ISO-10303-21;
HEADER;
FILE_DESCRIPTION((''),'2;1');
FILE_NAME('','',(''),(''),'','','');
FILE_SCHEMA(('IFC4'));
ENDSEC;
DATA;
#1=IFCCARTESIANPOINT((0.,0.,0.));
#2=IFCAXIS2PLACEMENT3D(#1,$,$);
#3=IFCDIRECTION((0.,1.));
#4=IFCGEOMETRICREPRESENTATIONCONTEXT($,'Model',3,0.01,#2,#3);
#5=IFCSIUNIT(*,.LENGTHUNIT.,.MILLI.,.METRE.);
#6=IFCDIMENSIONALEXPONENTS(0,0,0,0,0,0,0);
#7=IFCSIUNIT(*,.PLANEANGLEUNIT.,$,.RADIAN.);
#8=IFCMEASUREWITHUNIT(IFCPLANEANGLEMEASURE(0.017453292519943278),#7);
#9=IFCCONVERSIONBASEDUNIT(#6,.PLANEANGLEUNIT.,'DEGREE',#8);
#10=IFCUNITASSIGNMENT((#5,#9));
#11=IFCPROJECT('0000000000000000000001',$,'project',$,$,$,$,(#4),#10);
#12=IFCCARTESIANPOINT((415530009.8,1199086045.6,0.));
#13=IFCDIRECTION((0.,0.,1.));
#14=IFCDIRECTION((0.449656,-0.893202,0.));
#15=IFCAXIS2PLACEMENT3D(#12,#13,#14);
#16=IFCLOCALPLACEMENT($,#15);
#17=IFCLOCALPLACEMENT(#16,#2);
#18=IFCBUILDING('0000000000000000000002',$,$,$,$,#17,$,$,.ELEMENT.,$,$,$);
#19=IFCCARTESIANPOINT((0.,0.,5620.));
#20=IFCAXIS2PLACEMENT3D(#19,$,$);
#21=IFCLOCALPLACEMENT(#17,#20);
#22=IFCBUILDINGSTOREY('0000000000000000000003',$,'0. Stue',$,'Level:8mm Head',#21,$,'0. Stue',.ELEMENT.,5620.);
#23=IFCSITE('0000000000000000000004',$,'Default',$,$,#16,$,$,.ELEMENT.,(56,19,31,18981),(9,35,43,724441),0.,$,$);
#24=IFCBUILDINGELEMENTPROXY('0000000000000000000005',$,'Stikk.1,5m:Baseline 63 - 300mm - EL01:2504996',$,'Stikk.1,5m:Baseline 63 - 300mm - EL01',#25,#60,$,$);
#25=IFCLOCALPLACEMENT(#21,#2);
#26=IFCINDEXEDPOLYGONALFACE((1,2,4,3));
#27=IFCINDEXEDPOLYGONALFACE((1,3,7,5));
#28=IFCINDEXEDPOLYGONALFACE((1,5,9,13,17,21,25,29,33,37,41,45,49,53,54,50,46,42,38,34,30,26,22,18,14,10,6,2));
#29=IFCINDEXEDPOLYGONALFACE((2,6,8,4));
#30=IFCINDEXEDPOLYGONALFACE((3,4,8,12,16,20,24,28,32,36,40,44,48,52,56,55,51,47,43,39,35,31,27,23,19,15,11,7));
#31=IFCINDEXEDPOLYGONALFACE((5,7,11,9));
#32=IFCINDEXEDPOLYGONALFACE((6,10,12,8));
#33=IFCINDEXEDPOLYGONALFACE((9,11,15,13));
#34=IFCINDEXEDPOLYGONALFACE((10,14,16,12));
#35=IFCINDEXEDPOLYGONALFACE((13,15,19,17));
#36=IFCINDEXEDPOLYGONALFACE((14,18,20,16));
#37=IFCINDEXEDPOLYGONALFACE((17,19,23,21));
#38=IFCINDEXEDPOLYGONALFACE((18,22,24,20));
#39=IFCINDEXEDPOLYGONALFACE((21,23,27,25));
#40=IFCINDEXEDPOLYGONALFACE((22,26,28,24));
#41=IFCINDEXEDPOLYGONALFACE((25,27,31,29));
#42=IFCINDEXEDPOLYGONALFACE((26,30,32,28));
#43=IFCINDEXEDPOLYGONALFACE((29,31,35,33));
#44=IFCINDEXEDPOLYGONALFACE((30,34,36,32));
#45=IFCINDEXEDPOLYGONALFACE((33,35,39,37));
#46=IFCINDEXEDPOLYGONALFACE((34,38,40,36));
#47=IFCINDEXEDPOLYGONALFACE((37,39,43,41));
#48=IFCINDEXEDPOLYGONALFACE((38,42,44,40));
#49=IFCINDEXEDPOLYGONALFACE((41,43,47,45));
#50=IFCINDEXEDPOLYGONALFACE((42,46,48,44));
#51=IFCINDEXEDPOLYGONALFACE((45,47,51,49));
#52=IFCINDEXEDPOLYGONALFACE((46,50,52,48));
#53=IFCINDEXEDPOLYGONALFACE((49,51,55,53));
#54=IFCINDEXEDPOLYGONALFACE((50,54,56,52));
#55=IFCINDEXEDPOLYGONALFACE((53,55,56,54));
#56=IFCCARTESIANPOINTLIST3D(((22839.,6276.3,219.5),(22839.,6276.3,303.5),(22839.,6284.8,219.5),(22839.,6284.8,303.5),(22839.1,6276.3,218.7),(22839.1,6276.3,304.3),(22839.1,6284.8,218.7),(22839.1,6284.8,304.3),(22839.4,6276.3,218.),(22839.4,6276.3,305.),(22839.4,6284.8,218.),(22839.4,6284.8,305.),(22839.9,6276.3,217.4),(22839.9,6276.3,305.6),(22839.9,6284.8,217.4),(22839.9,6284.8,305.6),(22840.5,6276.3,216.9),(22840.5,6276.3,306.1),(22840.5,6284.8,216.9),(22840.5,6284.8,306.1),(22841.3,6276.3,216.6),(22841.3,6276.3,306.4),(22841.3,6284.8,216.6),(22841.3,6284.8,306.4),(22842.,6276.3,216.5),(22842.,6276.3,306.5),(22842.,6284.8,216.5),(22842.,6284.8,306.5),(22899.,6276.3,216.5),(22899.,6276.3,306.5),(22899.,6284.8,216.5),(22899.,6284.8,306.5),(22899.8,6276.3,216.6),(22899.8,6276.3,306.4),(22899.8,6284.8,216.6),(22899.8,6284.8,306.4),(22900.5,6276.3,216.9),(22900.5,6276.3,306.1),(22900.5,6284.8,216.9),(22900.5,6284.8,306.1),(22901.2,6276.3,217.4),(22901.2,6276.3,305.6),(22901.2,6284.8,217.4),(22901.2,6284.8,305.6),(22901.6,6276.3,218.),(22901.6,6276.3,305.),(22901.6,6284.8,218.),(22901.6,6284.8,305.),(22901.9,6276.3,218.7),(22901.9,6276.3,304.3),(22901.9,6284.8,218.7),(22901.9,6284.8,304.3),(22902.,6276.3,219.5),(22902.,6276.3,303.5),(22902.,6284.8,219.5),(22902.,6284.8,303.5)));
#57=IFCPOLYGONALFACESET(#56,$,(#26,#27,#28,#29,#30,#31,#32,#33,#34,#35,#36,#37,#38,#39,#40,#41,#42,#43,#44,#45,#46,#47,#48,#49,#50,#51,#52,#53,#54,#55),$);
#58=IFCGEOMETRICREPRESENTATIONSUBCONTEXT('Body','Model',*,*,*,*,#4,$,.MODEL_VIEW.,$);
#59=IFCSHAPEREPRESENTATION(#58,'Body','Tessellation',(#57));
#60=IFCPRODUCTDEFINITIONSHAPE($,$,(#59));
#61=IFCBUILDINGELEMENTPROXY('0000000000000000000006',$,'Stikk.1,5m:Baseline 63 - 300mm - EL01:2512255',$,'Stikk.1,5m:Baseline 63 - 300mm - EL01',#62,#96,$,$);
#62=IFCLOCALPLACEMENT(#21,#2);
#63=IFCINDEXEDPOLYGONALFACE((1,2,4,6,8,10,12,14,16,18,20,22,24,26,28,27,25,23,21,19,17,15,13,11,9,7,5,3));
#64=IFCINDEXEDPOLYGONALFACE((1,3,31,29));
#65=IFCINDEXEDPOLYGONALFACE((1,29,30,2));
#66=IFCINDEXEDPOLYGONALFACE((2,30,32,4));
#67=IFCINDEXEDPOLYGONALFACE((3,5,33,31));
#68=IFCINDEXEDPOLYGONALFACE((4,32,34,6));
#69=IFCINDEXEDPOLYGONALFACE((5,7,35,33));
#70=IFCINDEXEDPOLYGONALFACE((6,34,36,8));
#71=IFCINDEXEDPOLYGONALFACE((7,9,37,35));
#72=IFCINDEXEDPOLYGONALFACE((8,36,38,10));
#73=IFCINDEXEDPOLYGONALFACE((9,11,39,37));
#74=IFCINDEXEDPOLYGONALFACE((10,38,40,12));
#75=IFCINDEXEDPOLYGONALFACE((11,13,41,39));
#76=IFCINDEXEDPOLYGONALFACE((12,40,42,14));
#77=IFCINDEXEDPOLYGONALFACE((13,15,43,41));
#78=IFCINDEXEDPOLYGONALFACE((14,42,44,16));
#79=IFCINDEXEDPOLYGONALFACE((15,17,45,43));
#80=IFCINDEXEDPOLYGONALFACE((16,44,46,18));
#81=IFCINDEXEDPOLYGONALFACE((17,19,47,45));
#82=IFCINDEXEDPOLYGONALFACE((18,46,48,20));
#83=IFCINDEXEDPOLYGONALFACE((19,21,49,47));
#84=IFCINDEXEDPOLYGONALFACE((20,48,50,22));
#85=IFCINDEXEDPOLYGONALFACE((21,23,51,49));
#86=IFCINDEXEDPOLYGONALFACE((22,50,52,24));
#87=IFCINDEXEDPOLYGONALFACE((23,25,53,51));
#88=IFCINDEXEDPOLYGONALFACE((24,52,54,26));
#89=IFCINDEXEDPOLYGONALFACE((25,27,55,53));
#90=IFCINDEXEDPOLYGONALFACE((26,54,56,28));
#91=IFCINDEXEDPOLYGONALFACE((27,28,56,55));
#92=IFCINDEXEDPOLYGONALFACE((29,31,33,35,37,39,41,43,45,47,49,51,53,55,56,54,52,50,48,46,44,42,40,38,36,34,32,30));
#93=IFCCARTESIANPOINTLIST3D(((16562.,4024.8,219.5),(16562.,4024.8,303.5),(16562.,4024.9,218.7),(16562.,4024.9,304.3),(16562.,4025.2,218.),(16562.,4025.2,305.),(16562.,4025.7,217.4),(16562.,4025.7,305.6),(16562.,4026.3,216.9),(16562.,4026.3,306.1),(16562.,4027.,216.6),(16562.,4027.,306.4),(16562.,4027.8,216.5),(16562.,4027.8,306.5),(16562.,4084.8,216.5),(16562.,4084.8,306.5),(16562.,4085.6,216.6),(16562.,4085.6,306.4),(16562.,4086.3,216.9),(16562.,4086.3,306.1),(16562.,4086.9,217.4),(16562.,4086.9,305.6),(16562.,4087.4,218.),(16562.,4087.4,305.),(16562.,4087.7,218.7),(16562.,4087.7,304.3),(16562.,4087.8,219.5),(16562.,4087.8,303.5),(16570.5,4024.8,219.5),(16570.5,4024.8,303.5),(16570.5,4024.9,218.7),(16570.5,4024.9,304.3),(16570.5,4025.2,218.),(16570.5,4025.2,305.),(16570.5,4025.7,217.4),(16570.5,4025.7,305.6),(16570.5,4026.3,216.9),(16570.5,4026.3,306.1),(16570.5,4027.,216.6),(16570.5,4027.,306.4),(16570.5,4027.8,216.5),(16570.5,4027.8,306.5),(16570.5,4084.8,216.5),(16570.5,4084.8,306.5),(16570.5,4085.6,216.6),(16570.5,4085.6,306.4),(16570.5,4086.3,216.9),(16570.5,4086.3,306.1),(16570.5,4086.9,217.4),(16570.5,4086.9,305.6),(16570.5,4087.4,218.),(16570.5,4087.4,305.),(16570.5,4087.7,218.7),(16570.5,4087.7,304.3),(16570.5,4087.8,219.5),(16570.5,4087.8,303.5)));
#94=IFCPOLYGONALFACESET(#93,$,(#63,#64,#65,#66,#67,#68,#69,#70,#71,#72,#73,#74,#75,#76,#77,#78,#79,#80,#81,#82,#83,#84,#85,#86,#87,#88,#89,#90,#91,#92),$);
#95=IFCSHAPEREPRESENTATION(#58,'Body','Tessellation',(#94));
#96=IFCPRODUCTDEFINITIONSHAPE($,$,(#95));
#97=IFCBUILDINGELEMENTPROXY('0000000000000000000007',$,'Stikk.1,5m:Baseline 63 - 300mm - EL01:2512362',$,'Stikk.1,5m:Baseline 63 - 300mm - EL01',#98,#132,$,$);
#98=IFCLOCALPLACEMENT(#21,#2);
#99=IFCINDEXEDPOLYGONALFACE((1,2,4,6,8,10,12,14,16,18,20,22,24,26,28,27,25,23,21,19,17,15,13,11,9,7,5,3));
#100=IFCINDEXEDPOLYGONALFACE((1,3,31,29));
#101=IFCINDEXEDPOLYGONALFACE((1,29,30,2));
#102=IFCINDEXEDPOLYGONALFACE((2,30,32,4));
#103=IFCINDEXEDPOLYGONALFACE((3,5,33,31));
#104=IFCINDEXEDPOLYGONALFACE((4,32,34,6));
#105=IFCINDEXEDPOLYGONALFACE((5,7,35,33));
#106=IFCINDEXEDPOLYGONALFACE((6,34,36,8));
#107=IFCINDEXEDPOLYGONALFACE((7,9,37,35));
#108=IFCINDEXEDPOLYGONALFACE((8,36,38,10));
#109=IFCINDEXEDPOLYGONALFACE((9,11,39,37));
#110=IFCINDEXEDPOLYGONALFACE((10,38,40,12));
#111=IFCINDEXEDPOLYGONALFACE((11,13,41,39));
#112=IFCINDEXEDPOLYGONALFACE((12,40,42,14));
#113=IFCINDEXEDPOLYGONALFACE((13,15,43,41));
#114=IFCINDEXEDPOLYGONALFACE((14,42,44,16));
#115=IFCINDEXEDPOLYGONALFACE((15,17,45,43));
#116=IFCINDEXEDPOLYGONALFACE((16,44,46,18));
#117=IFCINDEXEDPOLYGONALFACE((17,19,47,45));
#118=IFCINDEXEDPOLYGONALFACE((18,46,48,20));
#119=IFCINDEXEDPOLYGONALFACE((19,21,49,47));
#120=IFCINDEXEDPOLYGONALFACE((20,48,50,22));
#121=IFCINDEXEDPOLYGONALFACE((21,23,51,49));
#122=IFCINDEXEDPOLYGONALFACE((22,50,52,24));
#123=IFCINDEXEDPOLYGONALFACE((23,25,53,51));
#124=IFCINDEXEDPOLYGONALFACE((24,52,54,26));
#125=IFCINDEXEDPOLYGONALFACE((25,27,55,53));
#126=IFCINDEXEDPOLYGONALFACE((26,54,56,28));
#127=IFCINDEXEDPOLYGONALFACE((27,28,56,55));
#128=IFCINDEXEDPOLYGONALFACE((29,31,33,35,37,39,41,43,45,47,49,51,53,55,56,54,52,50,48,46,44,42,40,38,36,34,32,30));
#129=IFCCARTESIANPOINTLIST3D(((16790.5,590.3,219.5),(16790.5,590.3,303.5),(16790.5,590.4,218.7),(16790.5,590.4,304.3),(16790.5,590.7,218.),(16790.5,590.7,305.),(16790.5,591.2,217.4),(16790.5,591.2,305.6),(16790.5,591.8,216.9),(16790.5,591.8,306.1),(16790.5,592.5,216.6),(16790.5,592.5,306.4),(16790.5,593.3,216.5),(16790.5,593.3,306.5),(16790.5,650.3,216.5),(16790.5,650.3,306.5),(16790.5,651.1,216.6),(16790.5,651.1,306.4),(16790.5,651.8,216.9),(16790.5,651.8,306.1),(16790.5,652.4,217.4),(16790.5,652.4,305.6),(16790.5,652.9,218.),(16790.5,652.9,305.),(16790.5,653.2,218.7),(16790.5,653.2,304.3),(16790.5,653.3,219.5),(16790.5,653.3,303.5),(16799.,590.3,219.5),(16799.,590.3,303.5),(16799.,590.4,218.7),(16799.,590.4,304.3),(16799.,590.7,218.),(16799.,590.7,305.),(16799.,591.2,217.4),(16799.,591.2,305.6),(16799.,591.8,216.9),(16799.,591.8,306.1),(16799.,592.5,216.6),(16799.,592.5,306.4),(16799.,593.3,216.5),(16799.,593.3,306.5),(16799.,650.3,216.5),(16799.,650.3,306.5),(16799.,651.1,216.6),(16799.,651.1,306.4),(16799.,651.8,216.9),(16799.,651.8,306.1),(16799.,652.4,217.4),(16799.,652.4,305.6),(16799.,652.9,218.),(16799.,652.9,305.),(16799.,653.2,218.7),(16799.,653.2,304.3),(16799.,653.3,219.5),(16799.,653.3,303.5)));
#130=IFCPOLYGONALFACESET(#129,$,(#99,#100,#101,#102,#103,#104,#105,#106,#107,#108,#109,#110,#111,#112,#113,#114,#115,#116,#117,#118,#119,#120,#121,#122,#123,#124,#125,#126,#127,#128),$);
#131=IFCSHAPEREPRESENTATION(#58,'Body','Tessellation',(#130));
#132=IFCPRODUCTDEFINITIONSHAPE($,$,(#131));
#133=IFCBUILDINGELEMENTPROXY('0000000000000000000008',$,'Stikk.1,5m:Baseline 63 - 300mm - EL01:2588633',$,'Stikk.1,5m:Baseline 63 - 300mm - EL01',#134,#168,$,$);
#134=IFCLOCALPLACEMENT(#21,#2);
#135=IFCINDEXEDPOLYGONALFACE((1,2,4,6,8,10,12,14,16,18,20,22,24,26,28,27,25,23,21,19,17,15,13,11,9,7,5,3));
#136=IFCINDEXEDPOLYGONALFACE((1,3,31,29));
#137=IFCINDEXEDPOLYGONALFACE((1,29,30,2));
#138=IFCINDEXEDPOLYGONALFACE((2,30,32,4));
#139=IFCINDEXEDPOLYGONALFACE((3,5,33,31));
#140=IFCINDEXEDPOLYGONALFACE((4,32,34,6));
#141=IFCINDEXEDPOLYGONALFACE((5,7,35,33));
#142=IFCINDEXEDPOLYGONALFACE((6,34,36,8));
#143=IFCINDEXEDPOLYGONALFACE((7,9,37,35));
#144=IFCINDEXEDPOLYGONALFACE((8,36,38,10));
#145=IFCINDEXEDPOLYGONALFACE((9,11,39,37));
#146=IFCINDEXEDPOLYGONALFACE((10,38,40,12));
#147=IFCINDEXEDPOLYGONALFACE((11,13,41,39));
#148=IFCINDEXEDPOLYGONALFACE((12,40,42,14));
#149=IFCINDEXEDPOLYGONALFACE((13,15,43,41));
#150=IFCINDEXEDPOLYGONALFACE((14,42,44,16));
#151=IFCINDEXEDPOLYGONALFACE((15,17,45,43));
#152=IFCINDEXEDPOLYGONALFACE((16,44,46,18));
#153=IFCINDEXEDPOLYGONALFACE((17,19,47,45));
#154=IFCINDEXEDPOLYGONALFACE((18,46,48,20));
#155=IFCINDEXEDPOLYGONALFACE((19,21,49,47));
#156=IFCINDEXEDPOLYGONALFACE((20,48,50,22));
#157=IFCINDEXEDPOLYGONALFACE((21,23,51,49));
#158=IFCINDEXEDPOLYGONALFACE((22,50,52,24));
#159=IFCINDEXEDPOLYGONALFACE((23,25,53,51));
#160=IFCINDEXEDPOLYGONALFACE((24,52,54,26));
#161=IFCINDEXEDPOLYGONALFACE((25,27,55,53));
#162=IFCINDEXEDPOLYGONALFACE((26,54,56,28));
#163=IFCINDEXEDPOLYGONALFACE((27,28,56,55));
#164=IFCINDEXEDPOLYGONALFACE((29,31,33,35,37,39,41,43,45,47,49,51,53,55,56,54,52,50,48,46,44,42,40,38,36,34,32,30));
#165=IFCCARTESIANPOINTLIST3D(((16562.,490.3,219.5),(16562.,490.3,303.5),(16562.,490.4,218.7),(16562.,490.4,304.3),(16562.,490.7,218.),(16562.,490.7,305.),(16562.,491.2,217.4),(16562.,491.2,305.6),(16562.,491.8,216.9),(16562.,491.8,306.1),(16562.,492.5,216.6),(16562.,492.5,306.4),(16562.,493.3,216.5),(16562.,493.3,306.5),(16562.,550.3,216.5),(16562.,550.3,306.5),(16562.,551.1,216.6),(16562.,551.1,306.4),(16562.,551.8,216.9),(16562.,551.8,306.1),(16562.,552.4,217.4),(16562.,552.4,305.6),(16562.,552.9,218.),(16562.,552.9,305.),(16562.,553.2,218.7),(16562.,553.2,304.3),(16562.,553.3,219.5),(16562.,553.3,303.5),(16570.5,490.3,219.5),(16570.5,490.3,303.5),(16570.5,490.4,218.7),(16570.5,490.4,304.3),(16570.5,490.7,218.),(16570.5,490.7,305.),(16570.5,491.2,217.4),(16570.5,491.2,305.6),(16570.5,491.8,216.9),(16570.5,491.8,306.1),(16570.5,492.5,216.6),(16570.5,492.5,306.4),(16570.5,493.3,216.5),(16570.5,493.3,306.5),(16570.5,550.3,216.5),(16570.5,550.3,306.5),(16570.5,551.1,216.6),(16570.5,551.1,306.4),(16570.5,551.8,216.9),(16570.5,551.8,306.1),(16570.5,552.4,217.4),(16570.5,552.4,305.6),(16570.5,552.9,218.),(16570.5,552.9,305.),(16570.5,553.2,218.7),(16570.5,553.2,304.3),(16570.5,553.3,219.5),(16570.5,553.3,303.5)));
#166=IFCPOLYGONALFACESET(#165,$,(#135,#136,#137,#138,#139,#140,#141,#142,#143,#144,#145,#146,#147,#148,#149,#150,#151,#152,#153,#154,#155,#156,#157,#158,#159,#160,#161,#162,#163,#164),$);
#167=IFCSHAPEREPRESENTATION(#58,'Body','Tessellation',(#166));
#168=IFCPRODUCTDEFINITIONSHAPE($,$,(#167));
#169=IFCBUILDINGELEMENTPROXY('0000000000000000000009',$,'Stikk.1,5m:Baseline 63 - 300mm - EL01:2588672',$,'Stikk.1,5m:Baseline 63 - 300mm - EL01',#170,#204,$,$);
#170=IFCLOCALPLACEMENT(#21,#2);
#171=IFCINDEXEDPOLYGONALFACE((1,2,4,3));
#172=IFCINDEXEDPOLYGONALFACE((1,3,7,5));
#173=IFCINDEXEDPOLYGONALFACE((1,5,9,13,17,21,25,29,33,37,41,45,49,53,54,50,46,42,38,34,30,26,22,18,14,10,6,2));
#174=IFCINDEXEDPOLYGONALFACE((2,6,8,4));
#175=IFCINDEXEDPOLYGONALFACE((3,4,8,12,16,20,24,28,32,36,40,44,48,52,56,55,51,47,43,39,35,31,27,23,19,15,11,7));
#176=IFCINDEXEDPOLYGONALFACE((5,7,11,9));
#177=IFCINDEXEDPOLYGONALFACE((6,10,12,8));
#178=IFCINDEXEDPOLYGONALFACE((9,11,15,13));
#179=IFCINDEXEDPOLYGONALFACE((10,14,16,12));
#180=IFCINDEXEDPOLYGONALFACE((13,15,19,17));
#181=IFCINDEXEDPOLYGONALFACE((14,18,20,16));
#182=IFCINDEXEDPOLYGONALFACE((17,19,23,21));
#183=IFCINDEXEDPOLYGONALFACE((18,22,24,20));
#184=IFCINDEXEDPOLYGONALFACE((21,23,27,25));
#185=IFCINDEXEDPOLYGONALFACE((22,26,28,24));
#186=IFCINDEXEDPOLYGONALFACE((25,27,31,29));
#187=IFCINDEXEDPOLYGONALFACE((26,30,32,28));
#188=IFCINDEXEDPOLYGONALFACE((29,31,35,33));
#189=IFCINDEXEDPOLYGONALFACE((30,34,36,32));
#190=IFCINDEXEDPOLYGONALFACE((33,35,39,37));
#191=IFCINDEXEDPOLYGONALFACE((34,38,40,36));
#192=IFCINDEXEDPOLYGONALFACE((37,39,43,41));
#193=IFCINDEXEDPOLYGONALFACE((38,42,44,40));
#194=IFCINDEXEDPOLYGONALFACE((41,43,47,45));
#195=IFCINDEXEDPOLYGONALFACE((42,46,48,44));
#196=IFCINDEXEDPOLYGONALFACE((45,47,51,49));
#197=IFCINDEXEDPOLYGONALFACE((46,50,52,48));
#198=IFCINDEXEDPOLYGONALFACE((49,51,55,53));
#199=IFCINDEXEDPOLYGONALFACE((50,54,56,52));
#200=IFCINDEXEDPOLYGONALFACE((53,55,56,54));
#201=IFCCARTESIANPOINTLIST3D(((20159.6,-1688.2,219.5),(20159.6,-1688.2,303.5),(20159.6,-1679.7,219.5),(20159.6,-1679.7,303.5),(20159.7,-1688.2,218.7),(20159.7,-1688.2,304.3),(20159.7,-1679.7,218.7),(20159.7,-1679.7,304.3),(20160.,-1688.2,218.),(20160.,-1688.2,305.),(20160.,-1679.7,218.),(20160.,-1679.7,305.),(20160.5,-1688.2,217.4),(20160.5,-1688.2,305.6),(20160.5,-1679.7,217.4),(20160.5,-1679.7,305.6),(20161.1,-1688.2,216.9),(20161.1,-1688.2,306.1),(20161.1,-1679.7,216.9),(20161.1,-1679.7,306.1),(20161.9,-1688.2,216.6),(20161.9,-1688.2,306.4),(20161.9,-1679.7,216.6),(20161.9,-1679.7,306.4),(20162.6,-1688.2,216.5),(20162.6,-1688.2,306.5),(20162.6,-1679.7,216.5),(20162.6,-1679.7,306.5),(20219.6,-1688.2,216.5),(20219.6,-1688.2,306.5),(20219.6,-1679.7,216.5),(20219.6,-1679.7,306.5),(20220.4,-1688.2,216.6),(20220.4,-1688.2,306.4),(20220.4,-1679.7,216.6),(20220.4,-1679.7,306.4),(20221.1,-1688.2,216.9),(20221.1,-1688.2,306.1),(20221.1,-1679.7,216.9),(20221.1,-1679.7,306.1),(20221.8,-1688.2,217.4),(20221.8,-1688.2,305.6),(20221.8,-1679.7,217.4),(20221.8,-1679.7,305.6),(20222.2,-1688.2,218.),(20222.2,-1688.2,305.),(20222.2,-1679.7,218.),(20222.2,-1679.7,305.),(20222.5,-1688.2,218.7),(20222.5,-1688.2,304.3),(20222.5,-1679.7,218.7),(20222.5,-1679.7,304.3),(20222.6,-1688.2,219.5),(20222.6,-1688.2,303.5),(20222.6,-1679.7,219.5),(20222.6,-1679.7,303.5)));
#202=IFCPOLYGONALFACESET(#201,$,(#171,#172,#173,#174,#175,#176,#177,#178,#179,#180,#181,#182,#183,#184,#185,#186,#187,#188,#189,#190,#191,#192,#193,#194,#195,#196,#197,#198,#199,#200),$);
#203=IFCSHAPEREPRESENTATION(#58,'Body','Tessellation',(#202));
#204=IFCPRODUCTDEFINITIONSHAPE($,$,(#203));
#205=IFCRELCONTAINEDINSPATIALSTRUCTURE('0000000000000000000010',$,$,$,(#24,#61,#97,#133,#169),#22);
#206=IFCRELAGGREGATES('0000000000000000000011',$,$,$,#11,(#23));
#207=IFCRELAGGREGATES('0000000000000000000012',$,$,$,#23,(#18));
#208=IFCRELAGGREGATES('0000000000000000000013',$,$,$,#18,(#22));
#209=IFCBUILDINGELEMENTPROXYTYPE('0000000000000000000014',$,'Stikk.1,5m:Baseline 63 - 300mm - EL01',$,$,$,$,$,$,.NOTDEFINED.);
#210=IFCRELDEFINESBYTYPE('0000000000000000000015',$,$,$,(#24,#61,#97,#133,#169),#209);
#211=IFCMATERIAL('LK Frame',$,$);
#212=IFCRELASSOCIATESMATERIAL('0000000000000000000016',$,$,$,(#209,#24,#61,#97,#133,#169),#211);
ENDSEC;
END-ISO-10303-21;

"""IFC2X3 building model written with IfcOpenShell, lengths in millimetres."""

from ifc_helpers import new_model, entity, si_unit, converted_unit, direction, frame, frame_2d, origin, place, context, subcontext, project, spatial, polyline, circle_curve, parameter, trimmed, segment, composite_curve, outline, extrude, source, transform, mapped, material, type_object, type_shapes, element, save


model = new_model("IFC2X3")

# Units and contexts
model_context = context("Model", 3, precision=0.01, world=origin(), true_north=direction((0.0, 1.0)))
body_context = subcontext(model_context, "Body", "Model", "MODEL_VIEW")
ifc_project = project(units=[si_unit("LENGTHUNIT", "METRE", prefix="MILLI"), converted_unit("PLANEANGLEUNIT", "DEGREE", entity("IfcPlaneAngleMeasure", 0.017453292519943278), si_unit("PLANEANGLEUNIT", "RADIAN"), dimensions=[0, 0, 0, 0, 0, 0, 0])], contexts=[model_context])

# Site, building, storey
site_placement = place(None, frame((415530009.8, 1199086045.6, 0.0), z_axis=(0.0, 0.0, 1.0), x_axis=(0.449656, -0.893202, 0.0)))
site = spatial("IfcSite", under=ifc_project, at=site_placement, Name="Default", CompositionType="ELEMENT", RefLatitude=(56, 19, 31, 18981), RefLongitude=(9, 35, 43, 724441), RefElevation=0.0)
building_placement = place(site_placement, origin())
building = spatial("IfcBuilding", under=site, at=building_placement, CompositionType="ELEMENT")
storey_placement = place(building_placement, frame((0.0, 0.0, 5620.0)))
storey = spatial("IfcBuildingStorey", under=building, at=storey_placement, Name="0. Stue", ObjectType="Level:8mm Head", LongName="0. Stue", CompositionType="ELEMENT", Elevation=5620.0)

# Building element proxies
ifc_material_1 = material(Name="LK Frame")
building_element_proxy_type_1 = type_object("IfcBuildingElementProxyType", Name="Stikk.1,5m:Baseline 63 - 300mm - EL01", PredefinedType="NOTDEFINED", material=ifc_material_1)
shared_shape_1 = source(origin(), body_context, "Body", "SweptSolid", [
    extrude(outline(composite_curve([segment(polyline([(-42.0, -31.5), (42.0, -31.5)]), True, "CONTINUOUS"), segment(trimmed(circle_curve(frame_2d((42.0, -28.5), x_axis=(-1.0, 0.0)), 3.0), [parameter(90.0)], [parameter(180.0)], True, "PARAMETER"), True, "CONTINUOUS"), segment(polyline([(45.0, -28.5), (45.0, 28.5)]), True, "CONTINUOUS"), segment(trimmed(circle_curve(frame_2d((42.0, 28.5), x_axis=(-1.0, 0.0)), 3.0), [parameter(180.0)], [parameter(270.0)], True, "PARAMETER"), True, "CONTINUOUS"), segment(polyline([(42.0, 31.5), (-42.0, 31.5)]), True, "CONTINUOUS"), segment(trimmed(circle_curve(frame_2d((-42.0, 28.5), x_axis=(1.0, 0.0)), 3.0), [parameter(90.0)], [parameter(180.0)], True, "PARAMETER"), True, "CONTINUOUS"), segment(polyline([(-45.0, 28.5), (-45.0, -28.5)]), True, "CONTINUOUS"), segment(trimmed(circle_curve(frame_2d((-42.0, -28.5), x_axis=(1.0, 0.0)), 3.0), [parameter(180.0)], [parameter(270.0)], True, "PARAMETER"), True, "CONTINUOUS")], self_intersect=False)), frame((0.0, -38.5, 0.0), z_axis=(0.0, 0.0, 1.0), x_axis=(0.0, 1.0, 0.0)), (0.0, 0.0, 1.0), 8.5),
])
type_shapes(building_element_proxy_type_1, [shared_shape_1])
for number, where, z_axis, x_axis, name in (
    (1, (22870.5, 6276.3, 300.0), (0.0, 1.0, 0.0), (-1.0, 0.0, 0.0), "Stikk.1,5m:Baseline 63 - 300mm - EL01:2504996"),
    (2, (16570.5, 4056.3, 300.0), (-1.0, 0.0, 0.0), (0.0, -1.0, 0.0), "Stikk.1,5m:Baseline 63 - 300mm - EL01:2512255"),
    (3, (16790.5, 621.8, 300.0), (1.0, 0.0, 0.0), (0.0, 1.0, 0.0), "Stikk.1,5m:Baseline 63 - 300mm - EL01:2512362"),
    (4, (16570.5, 521.8, 300.0), (-1.0, 0.0, 0.0), (0.0, -1.0, 0.0), "Stikk.1,5m:Baseline 63 - 300mm - EL01:2588633"),
    (5, (20191.1, -1688.2, 300.0), (0.0, 1.0, 0.0), (-1.0, 0.0, 0.0), "Stikk.1,5m:Baseline 63 - 300mm - EL01:2588672"),
):
    element("IfcBuildingElementProxy", number, at=place(storey_placement, frame(where, z_axis=z_axis, x_axis=x_axis)), inside=storey, type_object=building_element_proxy_type_1, material=ifc_material_1, Name=name, ObjectType="Stikk.1,5m:Baseline 63 - 300mm - EL01", context=body_context, shape_type="MappedRepresentation", body=[
        mapped(shared_shape_1, transform((0.0, 0.0, 0.0), scale=1.0)),
    ])

save(model, "model.ifc")
